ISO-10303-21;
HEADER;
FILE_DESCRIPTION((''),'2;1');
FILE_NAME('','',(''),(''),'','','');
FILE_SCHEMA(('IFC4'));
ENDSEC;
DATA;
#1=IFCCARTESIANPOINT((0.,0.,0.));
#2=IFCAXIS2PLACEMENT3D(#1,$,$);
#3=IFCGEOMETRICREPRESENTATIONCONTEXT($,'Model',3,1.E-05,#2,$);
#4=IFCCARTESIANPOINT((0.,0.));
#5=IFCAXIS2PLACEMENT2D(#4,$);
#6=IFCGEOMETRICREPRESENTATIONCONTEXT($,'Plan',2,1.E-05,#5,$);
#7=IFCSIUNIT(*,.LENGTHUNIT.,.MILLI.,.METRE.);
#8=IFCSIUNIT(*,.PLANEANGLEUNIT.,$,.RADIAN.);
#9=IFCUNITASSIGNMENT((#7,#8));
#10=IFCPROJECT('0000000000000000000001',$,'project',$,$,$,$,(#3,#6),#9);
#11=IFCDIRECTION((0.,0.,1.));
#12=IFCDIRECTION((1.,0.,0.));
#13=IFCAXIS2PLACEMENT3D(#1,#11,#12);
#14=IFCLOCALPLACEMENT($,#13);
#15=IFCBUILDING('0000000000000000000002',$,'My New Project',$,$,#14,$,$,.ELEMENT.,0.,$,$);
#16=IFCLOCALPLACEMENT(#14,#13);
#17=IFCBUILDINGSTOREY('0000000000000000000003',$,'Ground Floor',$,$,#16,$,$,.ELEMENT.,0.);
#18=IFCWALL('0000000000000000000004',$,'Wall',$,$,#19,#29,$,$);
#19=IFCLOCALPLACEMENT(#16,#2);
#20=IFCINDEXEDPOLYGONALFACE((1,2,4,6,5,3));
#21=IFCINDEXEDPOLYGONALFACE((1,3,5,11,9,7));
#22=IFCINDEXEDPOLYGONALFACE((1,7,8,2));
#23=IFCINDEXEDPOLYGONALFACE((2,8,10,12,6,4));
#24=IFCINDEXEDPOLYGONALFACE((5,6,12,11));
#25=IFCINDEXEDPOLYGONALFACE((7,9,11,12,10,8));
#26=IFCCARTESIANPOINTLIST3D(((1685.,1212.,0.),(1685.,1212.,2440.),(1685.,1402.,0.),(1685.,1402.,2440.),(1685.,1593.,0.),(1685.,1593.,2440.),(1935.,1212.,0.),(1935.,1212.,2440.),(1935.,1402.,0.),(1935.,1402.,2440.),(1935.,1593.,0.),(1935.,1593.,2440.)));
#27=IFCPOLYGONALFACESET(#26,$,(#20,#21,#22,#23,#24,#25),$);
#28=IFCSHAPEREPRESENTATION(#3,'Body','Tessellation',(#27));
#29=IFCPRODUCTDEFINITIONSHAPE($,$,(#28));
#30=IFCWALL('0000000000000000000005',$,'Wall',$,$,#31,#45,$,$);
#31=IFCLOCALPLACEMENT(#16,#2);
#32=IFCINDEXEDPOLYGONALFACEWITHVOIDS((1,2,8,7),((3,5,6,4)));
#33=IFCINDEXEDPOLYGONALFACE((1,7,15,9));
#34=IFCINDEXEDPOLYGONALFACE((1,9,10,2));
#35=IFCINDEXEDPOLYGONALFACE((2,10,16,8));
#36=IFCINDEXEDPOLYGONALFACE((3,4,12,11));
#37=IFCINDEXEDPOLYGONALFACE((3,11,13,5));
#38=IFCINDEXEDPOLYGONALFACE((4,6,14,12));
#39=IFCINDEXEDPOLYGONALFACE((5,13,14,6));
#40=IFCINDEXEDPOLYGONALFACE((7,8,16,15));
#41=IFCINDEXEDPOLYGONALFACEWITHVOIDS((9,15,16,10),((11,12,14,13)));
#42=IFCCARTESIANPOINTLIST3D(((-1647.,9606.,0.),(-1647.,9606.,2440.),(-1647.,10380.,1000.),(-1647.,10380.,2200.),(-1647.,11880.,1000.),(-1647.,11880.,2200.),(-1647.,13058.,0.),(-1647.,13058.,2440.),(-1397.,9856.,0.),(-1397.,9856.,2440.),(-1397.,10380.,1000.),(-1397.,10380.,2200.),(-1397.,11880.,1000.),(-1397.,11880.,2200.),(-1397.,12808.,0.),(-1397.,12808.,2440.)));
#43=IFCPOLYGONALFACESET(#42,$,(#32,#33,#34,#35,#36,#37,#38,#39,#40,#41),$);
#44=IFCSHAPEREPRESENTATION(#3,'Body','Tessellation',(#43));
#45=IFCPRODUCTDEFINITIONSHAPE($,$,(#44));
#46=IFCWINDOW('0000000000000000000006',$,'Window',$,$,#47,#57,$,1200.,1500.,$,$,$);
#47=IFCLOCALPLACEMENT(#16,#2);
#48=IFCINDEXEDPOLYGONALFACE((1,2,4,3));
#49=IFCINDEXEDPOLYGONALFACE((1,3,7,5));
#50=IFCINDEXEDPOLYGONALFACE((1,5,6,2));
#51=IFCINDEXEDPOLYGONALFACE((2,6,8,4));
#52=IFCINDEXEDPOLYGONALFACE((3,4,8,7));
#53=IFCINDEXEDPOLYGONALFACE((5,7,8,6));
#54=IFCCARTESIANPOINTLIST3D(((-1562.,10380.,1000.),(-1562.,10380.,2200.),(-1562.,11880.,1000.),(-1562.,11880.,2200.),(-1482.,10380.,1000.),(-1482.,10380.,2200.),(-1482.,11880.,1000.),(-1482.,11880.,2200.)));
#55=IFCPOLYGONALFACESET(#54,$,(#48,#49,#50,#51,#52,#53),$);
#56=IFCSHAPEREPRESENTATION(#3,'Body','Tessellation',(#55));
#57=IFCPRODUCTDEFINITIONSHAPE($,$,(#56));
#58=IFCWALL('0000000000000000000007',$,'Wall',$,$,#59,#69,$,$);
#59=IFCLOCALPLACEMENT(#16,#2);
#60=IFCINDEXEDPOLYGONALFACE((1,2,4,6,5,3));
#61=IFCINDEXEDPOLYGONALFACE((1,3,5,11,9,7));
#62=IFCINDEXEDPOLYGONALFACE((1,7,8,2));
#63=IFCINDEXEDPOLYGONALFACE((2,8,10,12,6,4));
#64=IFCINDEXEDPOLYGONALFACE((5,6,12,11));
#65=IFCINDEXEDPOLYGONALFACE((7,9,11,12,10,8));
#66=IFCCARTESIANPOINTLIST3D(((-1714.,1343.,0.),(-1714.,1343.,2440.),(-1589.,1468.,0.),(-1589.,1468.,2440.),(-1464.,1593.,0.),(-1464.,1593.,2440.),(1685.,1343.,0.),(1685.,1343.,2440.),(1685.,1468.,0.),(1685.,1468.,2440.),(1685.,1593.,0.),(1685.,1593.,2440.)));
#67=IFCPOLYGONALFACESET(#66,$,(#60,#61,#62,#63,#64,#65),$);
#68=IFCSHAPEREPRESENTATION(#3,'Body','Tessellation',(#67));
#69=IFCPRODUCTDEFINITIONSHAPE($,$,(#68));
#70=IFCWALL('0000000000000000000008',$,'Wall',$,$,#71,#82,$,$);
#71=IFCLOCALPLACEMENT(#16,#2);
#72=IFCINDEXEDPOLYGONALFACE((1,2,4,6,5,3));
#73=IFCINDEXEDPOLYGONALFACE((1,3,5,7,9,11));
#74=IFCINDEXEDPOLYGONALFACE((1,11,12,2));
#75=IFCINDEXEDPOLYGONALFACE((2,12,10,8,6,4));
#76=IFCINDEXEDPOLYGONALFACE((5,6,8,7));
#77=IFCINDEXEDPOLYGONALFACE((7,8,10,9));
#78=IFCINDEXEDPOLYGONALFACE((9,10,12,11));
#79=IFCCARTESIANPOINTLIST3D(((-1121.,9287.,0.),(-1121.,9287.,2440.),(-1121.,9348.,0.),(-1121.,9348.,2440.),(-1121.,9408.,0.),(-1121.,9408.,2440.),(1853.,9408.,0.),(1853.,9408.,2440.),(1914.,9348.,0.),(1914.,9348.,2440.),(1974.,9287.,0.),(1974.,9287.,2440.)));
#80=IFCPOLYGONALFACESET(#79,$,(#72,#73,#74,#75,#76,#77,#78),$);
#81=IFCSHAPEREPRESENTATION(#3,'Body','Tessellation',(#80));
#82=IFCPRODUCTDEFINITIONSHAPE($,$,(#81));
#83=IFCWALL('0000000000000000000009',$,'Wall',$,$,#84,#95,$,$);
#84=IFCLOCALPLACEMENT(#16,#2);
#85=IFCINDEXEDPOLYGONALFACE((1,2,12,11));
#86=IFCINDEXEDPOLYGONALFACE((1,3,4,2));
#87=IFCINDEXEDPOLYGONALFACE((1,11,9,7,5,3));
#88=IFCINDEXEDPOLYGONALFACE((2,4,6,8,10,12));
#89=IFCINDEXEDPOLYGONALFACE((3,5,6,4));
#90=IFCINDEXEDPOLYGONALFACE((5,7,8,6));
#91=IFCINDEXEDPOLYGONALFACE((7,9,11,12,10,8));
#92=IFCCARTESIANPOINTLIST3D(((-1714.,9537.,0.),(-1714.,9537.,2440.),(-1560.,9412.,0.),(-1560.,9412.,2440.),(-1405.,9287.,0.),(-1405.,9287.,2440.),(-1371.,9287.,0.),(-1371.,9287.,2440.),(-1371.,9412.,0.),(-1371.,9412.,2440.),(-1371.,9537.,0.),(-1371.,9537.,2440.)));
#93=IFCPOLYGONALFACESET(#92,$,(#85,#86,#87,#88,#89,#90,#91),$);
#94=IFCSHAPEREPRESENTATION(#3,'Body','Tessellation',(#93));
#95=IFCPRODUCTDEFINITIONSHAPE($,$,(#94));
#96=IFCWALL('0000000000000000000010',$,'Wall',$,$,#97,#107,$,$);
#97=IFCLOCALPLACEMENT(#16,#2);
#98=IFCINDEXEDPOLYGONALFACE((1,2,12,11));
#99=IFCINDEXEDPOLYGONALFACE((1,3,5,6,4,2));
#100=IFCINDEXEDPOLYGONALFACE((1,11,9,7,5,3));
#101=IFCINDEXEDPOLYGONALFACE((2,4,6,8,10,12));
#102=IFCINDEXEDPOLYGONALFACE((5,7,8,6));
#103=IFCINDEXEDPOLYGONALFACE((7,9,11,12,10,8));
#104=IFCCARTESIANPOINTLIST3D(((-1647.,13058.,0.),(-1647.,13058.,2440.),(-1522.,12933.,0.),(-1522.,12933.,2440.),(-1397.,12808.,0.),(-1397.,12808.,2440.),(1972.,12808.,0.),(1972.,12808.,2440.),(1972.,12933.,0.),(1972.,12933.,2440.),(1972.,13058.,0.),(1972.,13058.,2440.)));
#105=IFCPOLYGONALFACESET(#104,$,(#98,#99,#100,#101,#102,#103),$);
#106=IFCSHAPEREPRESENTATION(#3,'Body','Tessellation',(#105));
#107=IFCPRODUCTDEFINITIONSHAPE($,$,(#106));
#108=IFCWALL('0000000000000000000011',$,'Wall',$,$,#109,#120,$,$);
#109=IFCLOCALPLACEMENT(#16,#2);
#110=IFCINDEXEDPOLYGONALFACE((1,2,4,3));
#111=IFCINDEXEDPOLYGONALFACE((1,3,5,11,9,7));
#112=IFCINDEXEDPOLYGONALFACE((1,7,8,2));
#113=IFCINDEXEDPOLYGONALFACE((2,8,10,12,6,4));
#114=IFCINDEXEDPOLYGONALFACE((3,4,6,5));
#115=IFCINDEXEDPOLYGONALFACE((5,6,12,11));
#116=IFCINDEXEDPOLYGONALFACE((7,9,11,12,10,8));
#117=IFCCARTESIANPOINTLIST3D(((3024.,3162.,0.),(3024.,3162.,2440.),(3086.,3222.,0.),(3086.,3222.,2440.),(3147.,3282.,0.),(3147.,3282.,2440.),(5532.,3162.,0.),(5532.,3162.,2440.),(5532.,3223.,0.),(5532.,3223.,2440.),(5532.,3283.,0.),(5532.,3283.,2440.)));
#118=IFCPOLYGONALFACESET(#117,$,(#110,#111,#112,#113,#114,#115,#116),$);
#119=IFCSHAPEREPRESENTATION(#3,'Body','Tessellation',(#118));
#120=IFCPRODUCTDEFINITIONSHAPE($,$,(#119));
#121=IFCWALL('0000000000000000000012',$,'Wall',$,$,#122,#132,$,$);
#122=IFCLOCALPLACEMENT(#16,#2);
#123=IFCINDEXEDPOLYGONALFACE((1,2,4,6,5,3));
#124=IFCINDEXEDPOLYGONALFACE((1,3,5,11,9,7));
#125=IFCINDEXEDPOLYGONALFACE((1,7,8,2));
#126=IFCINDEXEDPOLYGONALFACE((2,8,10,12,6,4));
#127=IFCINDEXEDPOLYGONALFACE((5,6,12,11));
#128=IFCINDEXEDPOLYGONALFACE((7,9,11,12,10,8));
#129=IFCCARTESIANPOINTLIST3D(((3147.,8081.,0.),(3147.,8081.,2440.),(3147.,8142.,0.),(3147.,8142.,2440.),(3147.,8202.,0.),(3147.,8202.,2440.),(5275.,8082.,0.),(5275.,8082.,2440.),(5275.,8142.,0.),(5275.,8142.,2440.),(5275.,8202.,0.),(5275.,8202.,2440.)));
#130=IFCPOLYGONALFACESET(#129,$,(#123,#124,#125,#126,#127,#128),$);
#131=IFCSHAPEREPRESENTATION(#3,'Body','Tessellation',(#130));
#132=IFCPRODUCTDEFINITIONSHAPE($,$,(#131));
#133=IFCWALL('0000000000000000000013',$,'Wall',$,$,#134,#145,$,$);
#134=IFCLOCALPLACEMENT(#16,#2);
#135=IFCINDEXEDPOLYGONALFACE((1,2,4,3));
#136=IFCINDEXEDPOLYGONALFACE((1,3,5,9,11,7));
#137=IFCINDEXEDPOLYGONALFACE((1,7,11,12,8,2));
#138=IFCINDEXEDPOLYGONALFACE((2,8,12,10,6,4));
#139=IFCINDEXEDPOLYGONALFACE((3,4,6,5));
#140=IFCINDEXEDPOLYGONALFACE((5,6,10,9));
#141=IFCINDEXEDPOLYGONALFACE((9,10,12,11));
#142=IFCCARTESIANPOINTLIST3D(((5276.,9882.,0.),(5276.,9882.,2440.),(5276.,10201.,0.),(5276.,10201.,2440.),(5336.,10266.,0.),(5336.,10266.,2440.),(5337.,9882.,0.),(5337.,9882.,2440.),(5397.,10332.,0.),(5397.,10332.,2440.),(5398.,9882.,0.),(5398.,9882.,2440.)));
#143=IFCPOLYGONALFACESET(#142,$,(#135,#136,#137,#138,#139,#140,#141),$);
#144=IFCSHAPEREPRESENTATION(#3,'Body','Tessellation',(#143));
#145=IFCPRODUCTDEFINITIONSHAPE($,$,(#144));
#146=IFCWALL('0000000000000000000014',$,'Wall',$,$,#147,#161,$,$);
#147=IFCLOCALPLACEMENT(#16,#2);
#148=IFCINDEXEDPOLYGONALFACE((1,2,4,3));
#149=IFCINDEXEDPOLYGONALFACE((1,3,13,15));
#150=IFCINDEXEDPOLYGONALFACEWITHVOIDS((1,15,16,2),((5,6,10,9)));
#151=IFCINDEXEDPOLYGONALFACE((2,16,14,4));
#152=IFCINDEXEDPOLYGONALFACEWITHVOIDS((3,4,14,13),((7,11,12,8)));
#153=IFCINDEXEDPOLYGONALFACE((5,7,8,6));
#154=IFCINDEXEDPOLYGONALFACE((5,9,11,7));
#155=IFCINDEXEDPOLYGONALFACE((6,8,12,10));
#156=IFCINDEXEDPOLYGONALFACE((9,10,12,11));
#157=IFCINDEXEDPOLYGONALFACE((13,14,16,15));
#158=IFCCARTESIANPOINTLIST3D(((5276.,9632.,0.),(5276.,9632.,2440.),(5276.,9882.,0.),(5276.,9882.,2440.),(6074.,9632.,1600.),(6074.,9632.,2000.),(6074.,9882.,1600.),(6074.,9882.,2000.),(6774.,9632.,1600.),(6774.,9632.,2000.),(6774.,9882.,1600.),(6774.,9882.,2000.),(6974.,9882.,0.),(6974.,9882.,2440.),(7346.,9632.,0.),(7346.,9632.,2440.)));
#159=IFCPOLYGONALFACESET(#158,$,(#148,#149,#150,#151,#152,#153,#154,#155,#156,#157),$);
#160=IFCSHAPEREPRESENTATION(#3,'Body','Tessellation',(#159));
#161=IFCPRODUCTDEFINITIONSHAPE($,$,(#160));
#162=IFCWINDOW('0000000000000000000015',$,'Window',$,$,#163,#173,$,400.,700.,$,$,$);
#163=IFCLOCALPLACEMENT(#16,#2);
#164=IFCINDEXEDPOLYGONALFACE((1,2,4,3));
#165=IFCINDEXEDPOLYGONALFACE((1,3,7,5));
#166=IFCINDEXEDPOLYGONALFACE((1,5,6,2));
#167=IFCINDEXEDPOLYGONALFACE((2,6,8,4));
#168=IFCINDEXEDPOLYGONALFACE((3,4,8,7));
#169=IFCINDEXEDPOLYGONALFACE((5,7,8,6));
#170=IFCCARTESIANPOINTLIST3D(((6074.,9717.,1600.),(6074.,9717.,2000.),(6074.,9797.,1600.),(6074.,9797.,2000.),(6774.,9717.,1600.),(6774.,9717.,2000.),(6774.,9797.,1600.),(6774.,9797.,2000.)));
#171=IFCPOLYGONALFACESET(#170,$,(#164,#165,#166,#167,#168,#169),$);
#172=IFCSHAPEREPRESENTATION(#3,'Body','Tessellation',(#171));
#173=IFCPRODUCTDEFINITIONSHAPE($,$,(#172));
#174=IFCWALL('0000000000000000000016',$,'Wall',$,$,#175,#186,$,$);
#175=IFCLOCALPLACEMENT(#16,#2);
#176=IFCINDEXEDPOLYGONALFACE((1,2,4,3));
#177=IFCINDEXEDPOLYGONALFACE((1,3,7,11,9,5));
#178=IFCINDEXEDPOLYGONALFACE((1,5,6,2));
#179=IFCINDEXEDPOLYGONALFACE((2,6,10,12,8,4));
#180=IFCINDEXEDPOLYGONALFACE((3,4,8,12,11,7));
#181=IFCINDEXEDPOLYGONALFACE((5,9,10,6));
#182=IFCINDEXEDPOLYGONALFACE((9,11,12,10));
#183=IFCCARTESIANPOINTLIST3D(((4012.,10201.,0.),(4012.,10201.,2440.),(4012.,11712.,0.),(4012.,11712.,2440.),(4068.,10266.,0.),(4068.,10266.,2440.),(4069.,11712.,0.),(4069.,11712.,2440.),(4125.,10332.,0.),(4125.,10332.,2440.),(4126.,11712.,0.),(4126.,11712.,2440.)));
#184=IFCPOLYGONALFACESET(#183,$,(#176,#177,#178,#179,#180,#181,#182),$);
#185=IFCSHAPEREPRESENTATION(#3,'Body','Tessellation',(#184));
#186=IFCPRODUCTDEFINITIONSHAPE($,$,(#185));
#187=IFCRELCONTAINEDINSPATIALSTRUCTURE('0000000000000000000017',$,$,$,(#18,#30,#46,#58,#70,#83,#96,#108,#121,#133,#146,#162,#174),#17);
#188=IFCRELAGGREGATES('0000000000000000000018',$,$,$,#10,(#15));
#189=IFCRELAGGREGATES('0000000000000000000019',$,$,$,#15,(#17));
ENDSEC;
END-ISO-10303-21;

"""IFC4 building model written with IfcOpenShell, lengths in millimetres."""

from ifc_helpers import new_model, si_unit, frame, origin, origin_with_axes, origin_2d, origin_2d_with_axis, place, context, project, spatial, polyline, rectangle, outline, extrude, element, fill, save


model = new_model("IFC4")

# Units and contexts
model_context = context("Model", 3, precision=1e-05, world=origin())
plan_context = context("Plan", 2, precision=1e-05, world=origin_2d())
ifc_project = project(units=[si_unit("LENGTHUNIT", "METRE", prefix="MILLI"), si_unit("PLANEANGLEUNIT", "RADIAN")], contexts=[model_context, plan_context])

# Building, storey
building_placement = place(None, origin_with_axes())
building = spatial("IfcBuilding", under=ifc_project, at=building_placement, Name="My New Project", CompositionType="ELEMENT", ElevationOfRefHeight=0.0)
storey_placement = place(building_placement, origin_with_axes())
storey = spatial("IfcBuildingStorey", under=building, at=storey_placement, Name="Ground Floor", CompositionType="ELEMENT", Elevation=0.0)

# Wall
wall_1_placement = place(storey_placement, origin_with_axes())
element("IfcWall", 1, at=wall_1_placement, inside=storey, Name="Wall", context=model_context, shape_type="SweptSolid", body=[
    extrude(outline(polyline([(1685.0, 1402.0, 0.0), (1685.0, 1593.0, 0.0), (1935.0, 1593.0, 0.0), (1935.0, 1402.0, 0.0), (1935.0, 1212.0, 0.0), (1685.0, 1212.0, 0.0), (1685.0, 1402.0, 0.0)])), origin_with_axes(), (0.0, 0.0, 1.0), 2440.0),
])

# Wall, opening, window
wall_2_placement = place(storey_placement, origin_with_axes())
wall_2 = element("IfcWall", 2, at=wall_2_placement, inside=storey, Name="Wall", context=model_context, shape_type="SweptSolid", body=[
    extrude(outline(polyline([(-1522.0, 12933.0, 0.0), (-1397.0, 12808.0, 0.0), (-1397.0, 9856.0, 0.0), (-1522.0, 9731.0, 0.0), (-1647.0, 9606.0, 0.0), (-1647.0, 13058.0, 0.0), (-1522.0, 12933.0, 0.0)])), origin_with_axes(), (0.0, 0.0, 1.0), 2440.0),
])
opening_1_placement = place(wall_2_placement, frame((-1297.0, 11130.0, 1600.0), z_axis=(0.0, 0.0, 1.0), x_axis=(1.0, 0.0, 0.0)))
opening_1 = element("IfcOpeningElement", 3, at=opening_1_placement, cuts=wall_2, PredefinedType="OPENING", context=model_context, shape_type="SweptSolid", body=[
    extrude(rectangle(XDim=1500.0, YDim=1200.0, at=origin_2d_with_axis()), frame((0.0, 0.0, 0.0), z_axis=(-2952.0, 0.0, 0.0), x_axis=(0.0, -2952.0, 0.0)), (0.0, 0.0, 1.0), 450.0),
])
window_1_placement = place(opening_1_placement, frame((-185.0, 0.0, 0.0), z_axis=(0.0, 0.0, 1.0), x_axis=(1.0, 0.0, 0.0)))
window_1 = element("IfcWindow", 4, at=window_1_placement, inside=storey, Name="Window", OverallHeight=1200.0, OverallWidth=1500.0, context=model_context, shape_type="SweptSolid", body=[
    extrude(outline(polyline([(750.0, 600.0, 0.0), (750.0, -600.0, 0.0), (-750.0, -600.0, 0.0), (-750.0, 600.0, 0.0), (750.0, 600.0, 0.0)])), frame((0.0, 0.0, 0.0), z_axis=(-2952.0, 0.0, 0.0), x_axis=(0.0, -2952.0, 0.0)), (0.0, 0.0, 1.0), 80.0),
])
fill(opening_1, window_1)

# Walls
wall_3_placement = place(storey_placement, origin_with_axes())
element("IfcWall", 5, at=wall_3_placement, inside=storey, Name="Wall", context=model_context, shape_type="SweptSolid", body=[
    extrude(outline(polyline([(-1589.0, 1468.0, 0.0), (-1464.0, 1593.0, 0.0), (1685.0, 1593.0, 0.0), (1685.0, 1468.0, 0.0), (1685.0, 1343.0, 0.0), (-1714.0, 1343.0, 0.0), (-1589.0, 1468.0, 0.0)])), origin_with_axes(), (0.0, 0.0, 1.0), 2440.0),
])
wall_4_placement = place(storey_placement, origin_with_axes())
element("IfcWall", 6, at=wall_4_placement, inside=storey, Name="Wall", context=model_context, shape_type="SweptSolid", body=[
    extrude(outline(polyline([(-1121.0, 9348.0, 0.0), (-1121.0, 9408.0, 0.0), (1853.0, 9408.0, 0.0), (1914.0, 9348.0, 0.0), (1974.0, 9287.0, 0.0), (-1121.0, 9287.0, 0.0), (-1121.0, 9348.0, 0.0)])), origin_with_axes(), (0.0, 0.0, 1.0), 2440.0),
])
wall_5_placement = place(storey_placement, origin_with_axes())
element("IfcWall", 7, at=wall_5_placement, inside=storey, Name="Wall", context=model_context, shape_type="SweptSolid", body=[
    extrude(outline(polyline([(-1560.0, 9412.0, 0.0), (-1714.0, 9537.0, 0.0), (-1371.0, 9537.0, 0.0), (-1371.0, 9412.0, 0.0), (-1371.0, 9287.0, 0.0), (-1405.0, 9287.0, 0.0), (-1560.0, 9412.0, 0.0)])), origin_with_axes(), (0.0, 0.0, 1.0), 2440.0),
])
wall_6_placement = place(storey_placement, origin_with_axes())
element("IfcWall", 8, at=wall_6_placement, inside=storey, Name="Wall", context=model_context, shape_type="SweptSolid", body=[
    extrude(outline(polyline([(1972.0, 12933.0, 0.0), (1972.0, 12808.0, 0.0), (-1397.0, 12808.0, 0.0), (-1522.0, 12933.0, 0.0), (-1647.0, 13058.0, 0.0), (1972.0, 13058.0, 0.0), (1972.0, 12933.0, 0.0)])), origin_with_axes(), (0.0, 0.0, 1.0), 2440.0),
])
wall_7_placement = place(storey_placement, origin_with_axes())
element("IfcWall", 9, at=wall_7_placement, inside=storey, Name="Wall", context=model_context, shape_type="SweptSolid", body=[
    extrude(outline(polyline([(3086.0, 3222.0, 0.0), (3147.0, 3282.0, 0.0), (5532.0, 3283.0, 0.0), (5532.0, 3223.0, 0.0), (5532.0, 3162.0, 0.0), (3024.0, 3162.0, 0.0), (3086.0, 3222.0, 0.0)])), origin_with_axes(), (0.0, 0.0, 1.0), 2440.0),
])
wall_8_placement = place(storey_placement, origin_with_axes())
element("IfcWall", 10, at=wall_8_placement, inside=storey, Name="Wall", context=model_context, shape_type="SweptSolid", body=[
    extrude(outline(polyline([(5275.0, 8142.0, 0.0), (5275.0, 8082.0, 0.0), (3147.0, 8081.0, 0.0), (3147.0, 8142.0, 0.0), (3147.0, 8202.0, 0.0), (5275.0, 8202.0, 0.0), (5275.0, 8142.0, 0.0)])), origin_with_axes(), (0.0, 0.0, 1.0), 2440.0),
])
wall_9_placement = place(storey_placement, origin_with_axes())
element("IfcWall", 11, at=wall_9_placement, inside=storey, Name="Wall", context=model_context, shape_type="SweptSolid", body=[
    extrude(outline(polyline([(5336.0, 10266.0, 0.0), (5397.0, 10332.0, 0.0), (5398.0, 9882.0, 0.0), (5337.0, 9882.0, 0.0), (5276.0, 9882.0, 0.0), (5276.0, 10201.0, 0.0), (5336.0, 10266.0, 0.0)])), origin_with_axes(), (0.0, 0.0, 1.0), 2440.0),
])

# Wall, opening, window
wall_10_placement = place(storey_placement, origin_with_axes())
wall_10 = element("IfcWall", 12, at=wall_10_placement, inside=storey, Name="Wall", context=model_context, shape_type="SweptSolid", body=[
    extrude(outline(polyline([(5276.0, 9757.0, 0.0), (5276.0, 9882.0, 0.0), (6974.0, 9882.0, 0.0), (7160.0, 9757.0, 0.0), (7346.0, 9632.0, 0.0), (5276.0, 9632.0, 0.0), (5276.0, 9757.0, 0.0)])), origin_with_axes(), (0.0, 0.0, 1.0), 2440.0),
])
opening_2_placement = place(wall_10_placement, frame((6424.0, 9982.0, 1800.0), z_axis=(0.0, 0.0, 1.0), x_axis=(1.0, 0.0, 0.0)))
opening_2 = element("IfcOpeningElement", 13, at=opening_2_placement, cuts=wall_10, PredefinedType="OPENING", context=model_context, shape_type="SweptSolid", body=[
    extrude(rectangle(XDim=700.0, YDim=400.0, at=origin_2d_with_axis()), frame((0.0, 0.0, 0.0), z_axis=(0.0, -1698.0, 0.0), x_axis=(1698.0, 0.0, 0.0)), (0.0, 0.0, 1.0), 450.0),
])
window_2_placement = place(opening_2_placement, frame((0.0, -185.0, 0.0), z_axis=(0.0, 0.0, 1.0), x_axis=(1.0, 0.0, 0.0)))
window_2 = element("IfcWindow", 14, at=window_2_placement, inside=storey, Name="Window", OverallHeight=400.0, OverallWidth=700.0, context=model_context, shape_type="SweptSolid", body=[
    extrude(outline(polyline([(350.0, 200.0, 0.0), (350.0, -200.0, 0.0), (-350.0, -200.0, 0.0), (-350.0, 200.0, 0.0), (350.0, 200.0, 0.0)])), frame((0.0, 0.0, 0.0), z_axis=(0.0, -1698.0, 0.0), x_axis=(1698.0, 0.0, 0.0)), (0.0, 0.0, 1.0), 80.0),
])
fill(opening_2, window_2)

# Wall
wall_11_placement = place(storey_placement, origin_with_axes())
element("IfcWall", 15, at=wall_11_placement, inside=storey, Name="Wall", context=model_context, shape_type="SweptSolid", body=[
    extrude(outline(polyline([(4069.0, 11712.0, 0.0), (4126.0, 11712.0, 0.0), (4125.0, 10332.0, 0.0), (4068.0, 10266.0, 0.0), (4012.0, 10201.0, 0.0), (4012.0, 11712.0, 0.0), (4069.0, 11712.0, 0.0)])), origin_with_axes(), (0.0, 0.0, 1.0), 2440.0),
])

save(model, "model.ifc")
